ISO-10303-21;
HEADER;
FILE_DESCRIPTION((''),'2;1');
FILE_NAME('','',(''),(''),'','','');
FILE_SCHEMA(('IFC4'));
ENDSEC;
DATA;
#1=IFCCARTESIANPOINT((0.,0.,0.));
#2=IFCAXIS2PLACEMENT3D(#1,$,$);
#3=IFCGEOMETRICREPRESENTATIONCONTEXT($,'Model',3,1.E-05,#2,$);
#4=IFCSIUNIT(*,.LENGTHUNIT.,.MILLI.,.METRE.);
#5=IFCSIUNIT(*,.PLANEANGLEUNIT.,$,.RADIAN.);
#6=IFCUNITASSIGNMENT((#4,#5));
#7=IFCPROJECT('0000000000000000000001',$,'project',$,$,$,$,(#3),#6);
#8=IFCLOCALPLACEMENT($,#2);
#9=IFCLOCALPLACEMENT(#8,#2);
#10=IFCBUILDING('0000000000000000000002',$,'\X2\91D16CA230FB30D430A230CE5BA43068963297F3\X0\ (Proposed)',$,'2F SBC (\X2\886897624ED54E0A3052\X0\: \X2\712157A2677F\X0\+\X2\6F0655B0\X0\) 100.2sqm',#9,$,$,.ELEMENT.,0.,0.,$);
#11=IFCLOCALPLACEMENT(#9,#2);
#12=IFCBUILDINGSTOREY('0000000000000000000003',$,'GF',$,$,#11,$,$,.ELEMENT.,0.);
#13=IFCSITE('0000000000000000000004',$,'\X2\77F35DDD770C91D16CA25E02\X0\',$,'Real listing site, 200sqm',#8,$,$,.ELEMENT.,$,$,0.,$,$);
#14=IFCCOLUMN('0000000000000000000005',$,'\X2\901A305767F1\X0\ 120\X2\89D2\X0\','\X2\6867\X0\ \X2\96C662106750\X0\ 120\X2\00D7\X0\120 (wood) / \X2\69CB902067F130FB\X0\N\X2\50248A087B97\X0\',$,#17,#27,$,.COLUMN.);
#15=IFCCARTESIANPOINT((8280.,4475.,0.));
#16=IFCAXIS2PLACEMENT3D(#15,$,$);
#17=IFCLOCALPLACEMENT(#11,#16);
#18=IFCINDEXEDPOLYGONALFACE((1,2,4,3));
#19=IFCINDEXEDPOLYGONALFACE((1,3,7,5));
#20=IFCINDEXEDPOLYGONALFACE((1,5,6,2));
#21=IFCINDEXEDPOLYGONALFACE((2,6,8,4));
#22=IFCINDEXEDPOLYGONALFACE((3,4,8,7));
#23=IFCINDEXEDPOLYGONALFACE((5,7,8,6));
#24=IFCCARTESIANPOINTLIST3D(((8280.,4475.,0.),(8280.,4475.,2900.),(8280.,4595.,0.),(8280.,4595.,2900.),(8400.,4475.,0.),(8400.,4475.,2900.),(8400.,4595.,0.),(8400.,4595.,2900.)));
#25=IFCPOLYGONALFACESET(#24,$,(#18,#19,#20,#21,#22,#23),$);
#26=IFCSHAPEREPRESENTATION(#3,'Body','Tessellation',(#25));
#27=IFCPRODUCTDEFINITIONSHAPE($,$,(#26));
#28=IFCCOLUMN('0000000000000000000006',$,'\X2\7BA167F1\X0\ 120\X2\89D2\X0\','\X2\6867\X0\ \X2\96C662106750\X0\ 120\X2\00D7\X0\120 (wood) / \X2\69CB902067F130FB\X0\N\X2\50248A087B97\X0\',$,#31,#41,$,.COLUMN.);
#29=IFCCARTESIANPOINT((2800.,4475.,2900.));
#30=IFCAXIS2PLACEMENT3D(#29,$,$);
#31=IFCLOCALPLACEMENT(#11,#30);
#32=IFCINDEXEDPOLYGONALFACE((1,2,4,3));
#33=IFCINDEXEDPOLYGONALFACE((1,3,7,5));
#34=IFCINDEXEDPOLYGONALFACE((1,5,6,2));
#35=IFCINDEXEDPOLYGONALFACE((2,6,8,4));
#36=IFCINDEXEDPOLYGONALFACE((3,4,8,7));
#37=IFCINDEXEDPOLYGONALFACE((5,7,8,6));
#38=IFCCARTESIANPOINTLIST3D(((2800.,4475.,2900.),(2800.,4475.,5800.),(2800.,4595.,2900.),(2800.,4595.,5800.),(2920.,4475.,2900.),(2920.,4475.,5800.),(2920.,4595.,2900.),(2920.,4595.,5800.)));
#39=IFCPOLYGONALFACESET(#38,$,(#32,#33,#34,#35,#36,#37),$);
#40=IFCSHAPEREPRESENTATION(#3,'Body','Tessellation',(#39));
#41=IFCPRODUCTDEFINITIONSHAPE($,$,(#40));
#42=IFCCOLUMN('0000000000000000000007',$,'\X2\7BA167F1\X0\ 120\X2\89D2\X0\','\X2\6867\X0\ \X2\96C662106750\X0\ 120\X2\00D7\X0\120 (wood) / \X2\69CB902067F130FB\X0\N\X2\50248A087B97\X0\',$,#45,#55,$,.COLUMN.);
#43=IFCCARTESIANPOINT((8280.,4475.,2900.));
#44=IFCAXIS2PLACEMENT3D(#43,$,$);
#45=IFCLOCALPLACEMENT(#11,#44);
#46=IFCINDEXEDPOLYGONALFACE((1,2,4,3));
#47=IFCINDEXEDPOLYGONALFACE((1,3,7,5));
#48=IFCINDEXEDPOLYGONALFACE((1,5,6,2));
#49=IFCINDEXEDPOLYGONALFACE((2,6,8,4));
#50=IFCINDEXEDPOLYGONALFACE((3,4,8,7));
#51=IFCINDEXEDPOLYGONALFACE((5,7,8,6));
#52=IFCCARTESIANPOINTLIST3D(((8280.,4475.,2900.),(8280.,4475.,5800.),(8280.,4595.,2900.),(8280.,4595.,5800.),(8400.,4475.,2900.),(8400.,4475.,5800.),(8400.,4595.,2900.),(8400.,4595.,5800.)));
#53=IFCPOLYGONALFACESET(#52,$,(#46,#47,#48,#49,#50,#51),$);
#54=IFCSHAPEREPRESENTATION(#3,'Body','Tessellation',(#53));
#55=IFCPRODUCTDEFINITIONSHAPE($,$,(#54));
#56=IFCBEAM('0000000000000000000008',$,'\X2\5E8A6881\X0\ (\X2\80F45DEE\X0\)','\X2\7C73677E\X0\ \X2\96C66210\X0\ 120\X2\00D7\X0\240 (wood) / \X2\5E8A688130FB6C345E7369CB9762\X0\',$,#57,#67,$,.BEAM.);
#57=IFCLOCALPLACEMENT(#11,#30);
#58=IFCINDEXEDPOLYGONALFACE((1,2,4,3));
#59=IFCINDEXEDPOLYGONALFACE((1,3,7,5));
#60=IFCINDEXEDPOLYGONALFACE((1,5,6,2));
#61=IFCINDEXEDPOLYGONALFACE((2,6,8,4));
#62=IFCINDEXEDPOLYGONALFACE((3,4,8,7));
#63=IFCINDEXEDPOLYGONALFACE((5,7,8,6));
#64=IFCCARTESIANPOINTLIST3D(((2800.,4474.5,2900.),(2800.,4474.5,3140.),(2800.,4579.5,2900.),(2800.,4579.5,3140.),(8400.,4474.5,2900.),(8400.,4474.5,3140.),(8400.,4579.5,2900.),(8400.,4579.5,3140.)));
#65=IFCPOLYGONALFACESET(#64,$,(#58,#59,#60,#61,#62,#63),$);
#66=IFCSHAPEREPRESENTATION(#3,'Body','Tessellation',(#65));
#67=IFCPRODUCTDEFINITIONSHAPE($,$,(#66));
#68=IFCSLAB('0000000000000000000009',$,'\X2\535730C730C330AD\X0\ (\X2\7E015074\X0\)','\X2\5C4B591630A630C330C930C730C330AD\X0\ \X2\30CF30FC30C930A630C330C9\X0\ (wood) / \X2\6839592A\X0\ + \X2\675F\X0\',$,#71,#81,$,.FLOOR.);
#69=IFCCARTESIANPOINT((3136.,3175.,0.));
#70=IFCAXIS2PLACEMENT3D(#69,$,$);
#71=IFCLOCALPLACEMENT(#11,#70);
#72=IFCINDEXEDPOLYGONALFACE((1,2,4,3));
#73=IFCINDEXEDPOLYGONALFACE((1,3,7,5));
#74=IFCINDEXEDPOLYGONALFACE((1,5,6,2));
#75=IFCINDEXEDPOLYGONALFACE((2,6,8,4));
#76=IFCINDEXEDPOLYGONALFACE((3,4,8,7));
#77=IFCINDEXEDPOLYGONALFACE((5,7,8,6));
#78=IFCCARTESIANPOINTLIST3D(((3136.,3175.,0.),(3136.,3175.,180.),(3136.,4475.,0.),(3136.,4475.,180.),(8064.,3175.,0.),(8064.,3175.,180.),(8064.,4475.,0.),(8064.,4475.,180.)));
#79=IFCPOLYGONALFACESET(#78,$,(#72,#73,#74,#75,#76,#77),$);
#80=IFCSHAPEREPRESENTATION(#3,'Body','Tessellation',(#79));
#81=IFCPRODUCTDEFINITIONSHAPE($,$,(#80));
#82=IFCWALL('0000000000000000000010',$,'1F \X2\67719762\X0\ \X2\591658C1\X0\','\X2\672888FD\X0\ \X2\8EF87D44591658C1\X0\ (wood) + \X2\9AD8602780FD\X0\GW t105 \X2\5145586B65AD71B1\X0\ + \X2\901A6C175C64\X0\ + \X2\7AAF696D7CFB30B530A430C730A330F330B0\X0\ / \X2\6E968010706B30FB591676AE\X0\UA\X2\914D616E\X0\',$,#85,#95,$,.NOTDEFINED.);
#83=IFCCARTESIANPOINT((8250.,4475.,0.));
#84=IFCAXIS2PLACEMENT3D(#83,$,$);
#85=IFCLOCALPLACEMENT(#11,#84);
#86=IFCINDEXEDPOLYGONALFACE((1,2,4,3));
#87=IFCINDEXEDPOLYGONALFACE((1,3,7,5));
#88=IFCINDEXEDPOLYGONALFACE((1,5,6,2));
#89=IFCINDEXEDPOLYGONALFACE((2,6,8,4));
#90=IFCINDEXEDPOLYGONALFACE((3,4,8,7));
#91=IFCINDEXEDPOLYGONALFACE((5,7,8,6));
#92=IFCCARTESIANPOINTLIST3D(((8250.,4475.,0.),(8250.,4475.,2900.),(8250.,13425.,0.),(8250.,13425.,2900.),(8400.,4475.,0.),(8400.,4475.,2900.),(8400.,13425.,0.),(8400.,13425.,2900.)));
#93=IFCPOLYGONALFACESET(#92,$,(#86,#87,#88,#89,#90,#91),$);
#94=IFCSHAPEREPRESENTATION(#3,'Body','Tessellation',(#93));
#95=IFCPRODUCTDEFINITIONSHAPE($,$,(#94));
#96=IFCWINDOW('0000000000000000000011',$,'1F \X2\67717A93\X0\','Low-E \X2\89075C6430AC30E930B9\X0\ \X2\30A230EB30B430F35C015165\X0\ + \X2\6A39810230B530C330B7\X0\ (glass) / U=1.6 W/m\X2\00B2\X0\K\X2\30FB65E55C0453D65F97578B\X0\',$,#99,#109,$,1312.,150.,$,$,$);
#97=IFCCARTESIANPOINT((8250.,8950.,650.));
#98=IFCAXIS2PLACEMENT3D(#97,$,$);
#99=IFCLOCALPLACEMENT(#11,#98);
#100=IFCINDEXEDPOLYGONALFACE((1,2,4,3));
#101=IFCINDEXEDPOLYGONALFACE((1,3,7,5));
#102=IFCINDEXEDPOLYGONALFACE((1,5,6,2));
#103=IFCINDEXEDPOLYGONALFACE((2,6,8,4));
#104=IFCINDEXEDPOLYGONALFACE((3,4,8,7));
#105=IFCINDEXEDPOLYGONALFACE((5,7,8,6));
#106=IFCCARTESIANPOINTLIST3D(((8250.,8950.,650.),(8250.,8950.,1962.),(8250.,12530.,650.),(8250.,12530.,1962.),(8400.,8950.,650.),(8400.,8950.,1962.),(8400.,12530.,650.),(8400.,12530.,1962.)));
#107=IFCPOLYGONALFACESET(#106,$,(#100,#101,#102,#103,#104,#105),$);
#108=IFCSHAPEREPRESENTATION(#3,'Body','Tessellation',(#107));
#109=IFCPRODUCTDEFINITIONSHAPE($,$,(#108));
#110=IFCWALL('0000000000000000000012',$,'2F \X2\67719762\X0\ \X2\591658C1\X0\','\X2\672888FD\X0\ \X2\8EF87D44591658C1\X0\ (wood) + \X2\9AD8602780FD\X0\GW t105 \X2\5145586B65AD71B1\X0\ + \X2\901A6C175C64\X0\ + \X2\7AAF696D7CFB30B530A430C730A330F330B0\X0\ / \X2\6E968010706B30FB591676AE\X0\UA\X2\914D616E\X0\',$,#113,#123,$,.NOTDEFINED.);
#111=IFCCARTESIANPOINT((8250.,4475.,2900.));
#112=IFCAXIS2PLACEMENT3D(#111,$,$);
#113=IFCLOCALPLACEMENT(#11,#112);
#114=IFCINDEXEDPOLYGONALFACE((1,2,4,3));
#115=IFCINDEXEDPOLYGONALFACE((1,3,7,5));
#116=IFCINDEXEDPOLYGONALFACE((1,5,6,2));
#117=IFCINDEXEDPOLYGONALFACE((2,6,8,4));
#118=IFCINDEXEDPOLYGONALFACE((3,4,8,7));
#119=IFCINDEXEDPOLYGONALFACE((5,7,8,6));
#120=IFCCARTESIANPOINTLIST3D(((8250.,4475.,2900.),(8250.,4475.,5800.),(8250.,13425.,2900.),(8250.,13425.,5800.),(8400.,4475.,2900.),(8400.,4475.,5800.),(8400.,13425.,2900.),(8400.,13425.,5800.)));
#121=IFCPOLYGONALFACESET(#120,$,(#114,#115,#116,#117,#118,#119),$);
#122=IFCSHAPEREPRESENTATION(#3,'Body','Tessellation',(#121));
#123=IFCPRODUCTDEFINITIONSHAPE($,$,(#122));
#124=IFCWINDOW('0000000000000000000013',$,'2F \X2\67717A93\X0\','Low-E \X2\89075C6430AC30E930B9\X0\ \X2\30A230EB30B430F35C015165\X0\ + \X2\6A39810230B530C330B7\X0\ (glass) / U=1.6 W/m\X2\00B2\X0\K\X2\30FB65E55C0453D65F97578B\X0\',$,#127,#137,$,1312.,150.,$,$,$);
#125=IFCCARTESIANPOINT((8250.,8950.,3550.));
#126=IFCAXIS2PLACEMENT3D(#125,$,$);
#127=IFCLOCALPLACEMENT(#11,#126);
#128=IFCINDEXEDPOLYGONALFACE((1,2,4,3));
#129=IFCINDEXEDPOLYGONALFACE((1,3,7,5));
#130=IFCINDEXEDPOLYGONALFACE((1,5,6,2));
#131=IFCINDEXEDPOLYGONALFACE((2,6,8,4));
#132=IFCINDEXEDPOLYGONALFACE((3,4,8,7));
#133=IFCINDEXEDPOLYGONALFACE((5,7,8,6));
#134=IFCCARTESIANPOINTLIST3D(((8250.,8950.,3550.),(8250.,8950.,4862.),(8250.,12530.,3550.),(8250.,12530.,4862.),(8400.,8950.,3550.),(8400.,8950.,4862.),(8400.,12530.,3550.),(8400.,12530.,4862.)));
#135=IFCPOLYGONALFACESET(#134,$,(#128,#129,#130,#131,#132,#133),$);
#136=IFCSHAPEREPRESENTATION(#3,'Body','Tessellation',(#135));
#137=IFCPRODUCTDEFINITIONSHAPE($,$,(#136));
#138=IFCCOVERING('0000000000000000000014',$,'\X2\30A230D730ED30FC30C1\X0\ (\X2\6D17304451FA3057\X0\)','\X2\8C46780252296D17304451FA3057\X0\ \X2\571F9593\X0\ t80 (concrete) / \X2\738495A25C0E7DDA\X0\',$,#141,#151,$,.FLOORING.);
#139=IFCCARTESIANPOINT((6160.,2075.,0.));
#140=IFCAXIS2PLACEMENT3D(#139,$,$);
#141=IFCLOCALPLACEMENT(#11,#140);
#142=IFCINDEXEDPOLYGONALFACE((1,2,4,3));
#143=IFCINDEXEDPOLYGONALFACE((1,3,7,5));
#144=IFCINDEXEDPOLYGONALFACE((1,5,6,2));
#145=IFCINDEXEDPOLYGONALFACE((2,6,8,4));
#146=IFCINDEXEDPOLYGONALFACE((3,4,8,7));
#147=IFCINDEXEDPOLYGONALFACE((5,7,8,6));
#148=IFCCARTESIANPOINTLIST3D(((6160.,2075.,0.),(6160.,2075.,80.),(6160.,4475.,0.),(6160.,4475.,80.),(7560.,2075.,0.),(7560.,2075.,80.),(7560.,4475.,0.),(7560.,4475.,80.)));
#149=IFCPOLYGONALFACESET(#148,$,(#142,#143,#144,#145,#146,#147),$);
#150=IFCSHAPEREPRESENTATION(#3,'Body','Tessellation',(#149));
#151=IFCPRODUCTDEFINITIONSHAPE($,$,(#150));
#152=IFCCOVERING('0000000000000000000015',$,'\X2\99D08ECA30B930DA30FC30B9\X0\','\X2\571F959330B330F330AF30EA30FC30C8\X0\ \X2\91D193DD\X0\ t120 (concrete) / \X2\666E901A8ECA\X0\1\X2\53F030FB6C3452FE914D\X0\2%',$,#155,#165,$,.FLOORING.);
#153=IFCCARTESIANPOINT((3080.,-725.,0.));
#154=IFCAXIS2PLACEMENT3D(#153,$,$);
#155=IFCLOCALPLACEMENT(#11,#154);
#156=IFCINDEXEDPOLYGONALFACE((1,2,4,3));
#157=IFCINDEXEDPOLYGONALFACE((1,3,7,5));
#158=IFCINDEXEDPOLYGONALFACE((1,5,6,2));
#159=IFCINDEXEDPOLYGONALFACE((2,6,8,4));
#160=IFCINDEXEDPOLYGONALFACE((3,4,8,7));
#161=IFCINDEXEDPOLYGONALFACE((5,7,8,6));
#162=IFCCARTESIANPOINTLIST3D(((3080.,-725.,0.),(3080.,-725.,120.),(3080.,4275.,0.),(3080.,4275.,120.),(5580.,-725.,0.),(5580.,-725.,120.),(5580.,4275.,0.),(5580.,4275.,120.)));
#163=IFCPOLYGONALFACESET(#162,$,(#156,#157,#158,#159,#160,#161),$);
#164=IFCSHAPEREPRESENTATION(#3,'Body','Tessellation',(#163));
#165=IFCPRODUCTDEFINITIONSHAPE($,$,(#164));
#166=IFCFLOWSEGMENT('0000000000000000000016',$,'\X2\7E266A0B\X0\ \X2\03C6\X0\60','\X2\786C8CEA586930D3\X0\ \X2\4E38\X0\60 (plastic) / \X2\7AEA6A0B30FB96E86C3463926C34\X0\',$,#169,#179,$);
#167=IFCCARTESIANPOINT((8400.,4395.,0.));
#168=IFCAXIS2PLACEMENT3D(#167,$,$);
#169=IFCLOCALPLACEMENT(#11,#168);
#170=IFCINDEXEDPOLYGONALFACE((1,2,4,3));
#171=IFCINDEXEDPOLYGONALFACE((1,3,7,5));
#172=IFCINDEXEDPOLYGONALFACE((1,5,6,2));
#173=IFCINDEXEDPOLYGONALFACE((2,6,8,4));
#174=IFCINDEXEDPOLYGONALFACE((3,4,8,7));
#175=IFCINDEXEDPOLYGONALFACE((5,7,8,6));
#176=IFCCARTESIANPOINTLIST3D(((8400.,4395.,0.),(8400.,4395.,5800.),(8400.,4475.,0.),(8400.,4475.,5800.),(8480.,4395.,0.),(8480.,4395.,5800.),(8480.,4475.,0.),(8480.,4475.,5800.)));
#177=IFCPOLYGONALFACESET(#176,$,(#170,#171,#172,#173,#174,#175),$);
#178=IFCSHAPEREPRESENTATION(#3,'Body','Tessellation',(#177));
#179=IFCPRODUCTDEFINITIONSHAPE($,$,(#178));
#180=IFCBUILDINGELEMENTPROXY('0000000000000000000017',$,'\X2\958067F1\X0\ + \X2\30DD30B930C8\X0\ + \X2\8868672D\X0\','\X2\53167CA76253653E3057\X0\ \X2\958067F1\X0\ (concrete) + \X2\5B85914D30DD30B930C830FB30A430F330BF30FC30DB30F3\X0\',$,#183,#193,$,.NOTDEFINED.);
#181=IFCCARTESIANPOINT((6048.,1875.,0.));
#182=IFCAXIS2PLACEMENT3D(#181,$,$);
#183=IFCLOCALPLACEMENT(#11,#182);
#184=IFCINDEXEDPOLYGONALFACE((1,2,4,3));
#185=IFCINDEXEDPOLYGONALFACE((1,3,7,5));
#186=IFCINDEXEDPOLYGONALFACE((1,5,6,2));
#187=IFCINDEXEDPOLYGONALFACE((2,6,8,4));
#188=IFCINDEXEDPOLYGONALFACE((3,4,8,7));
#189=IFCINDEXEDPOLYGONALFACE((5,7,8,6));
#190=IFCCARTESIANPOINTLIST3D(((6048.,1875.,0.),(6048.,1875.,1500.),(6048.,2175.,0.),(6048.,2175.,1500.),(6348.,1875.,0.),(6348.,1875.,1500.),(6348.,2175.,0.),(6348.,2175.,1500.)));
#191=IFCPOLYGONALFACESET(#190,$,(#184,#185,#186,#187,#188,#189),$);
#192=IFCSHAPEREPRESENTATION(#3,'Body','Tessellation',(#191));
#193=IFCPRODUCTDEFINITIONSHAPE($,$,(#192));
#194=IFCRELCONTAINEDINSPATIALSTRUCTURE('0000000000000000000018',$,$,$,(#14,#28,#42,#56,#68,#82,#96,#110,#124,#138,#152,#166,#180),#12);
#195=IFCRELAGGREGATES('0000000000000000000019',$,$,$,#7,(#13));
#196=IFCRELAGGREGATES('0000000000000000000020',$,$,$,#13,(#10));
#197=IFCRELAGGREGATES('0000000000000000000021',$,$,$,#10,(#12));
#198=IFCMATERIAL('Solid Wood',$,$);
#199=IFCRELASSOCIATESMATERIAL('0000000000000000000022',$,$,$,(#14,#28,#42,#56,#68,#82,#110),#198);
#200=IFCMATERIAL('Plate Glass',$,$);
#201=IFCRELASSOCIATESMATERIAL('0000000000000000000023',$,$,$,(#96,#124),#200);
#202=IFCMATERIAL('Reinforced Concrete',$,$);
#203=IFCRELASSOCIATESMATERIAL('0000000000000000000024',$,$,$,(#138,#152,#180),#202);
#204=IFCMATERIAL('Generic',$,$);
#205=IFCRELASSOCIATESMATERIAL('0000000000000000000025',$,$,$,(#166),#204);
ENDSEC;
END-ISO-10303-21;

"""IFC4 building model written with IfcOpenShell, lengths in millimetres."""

from ifc_helpers import new_model, si_unit, frame, frame_2d, origin, place, context, project, spatial, rectangle, extrude, material, element, fill, save


model = new_model("IFC4")

# Units and contexts
model_context = context("Model", 3, precision=1e-05, world=origin())
ifc_project = project(units=[si_unit("LENGTHUNIT", "METRE", prefix="MILLI"), si_unit("PLANEANGLEUNIT", "RADIAN")], contexts=[model_context])

# Site, building, storey
site_placement = place(None, origin())
site = spatial("IfcSite", under=ifc_project, at=site_placement, Name="石川県金沢市", ObjectType="Real listing site, 200sqm", CompositionType="ELEMENT", RefElevation=0.0)
building_placement = place(site_placement, origin())
building = spatial("IfcBuilding", under=site, at=building_placement, Name="金沢・ピアノ室と防音 (Proposed)", ObjectType="2F SBC (表面仕上げ: 無垢板+漆喰) 100.2sqm", CompositionType="ELEMENT", ElevationOfRefHeight=0.0, ElevationOfTerrain=0.0)
storey_placement = place(building_placement, origin())
storey = spatial("IfcBuildingStorey", under=building, at=storey_placement, Name="GF", CompositionType="ELEMENT", Elevation=0.0)

# Columns
ifc_material_1 = material(Name="Solid Wood")
column_1_placement = place(storey_placement, frame((8280.0, 4475.0, 0.0)))
element("IfcColumn", 1, at=column_1_placement, inside=storey, material=ifc_material_1, Name="通し柱 120角", Description="桧 集成材 120×120 (wood) / 構造柱・N値計算", PredefinedType="COLUMN", context=model_context, shape_type="SweptSolid", body=[
    extrude(rectangle(XDim=120.0, YDim=120.0, at=frame_2d((60.0, 60.0))), frame((8280.0, 4475.0, 0.0)), (0.0, 0.0, 1.0), 2900.0),
])
column_2_placement = place(storey_placement, frame((2800.0, 4475.0, 2900.0)))
element("IfcColumn", 2, at=column_2_placement, inside=storey, material=ifc_material_1, Name="管柱 120角", Description="桧 集成材 120×120 (wood) / 構造柱・N値計算", PredefinedType="COLUMN", context=model_context, shape_type="SweptSolid", body=[
    extrude(rectangle(XDim=120.0, YDim=120.0, at=frame_2d((60.0, 60.0))), frame((2800.0, 4475.0, 2900.0)), (0.0, 0.0, 1.0), 2900.0),
])
column_3_placement = place(storey_placement, frame((8280.0, 4475.0, 2900.0)))
element("IfcColumn", 3, at=column_3_placement, inside=storey, material=ifc_material_1, Name="管柱 120角", Description="桧 集成材 120×120 (wood) / 構造柱・N値計算", PredefinedType="COLUMN", context=model_context, shape_type="SweptSolid", body=[
    extrude(rectangle(XDim=120.0, YDim=120.0, at=frame_2d((60.0, 60.0))), frame((8280.0, 4475.0, 2900.0)), (0.0, 0.0, 1.0), 2900.0),
])

# Beam
beam_1_placement = place(storey_placement, frame((2800.0, 4475.0, 2900.0)))
element("IfcBeam", 4, at=beam_1_placement, inside=storey, material=ifc_material_1, Name="床梁 (胴差)", Description="米松 集成 120×240 (wood) / 床梁・水平構面", PredefinedType="BEAM", context=model_context, shape_type="SweptSolid", body=[
    extrude(rectangle(XDim=5600.0, YDim=105.0, at=frame_2d((2800.0, 52.0))), frame((2800.0, 4475.0, 2900.0)), (0.0, 0.0, 1.0), 240.0),
])

# Slab
slab_placement = place(storey_placement, frame((3136.0, 3175.0, 0.0)))
element("IfcSlab", 5, at=slab_placement, inside=storey, material=ifc_material_1, Name="南デッキ (縁側)", Description="屋外ウッドデッキ ハードウッド (wood) / 根太 + 束", PredefinedType="FLOOR", context=model_context, shape_type="SweptSolid", body=[
    extrude(rectangle(XDim=4928.0, YDim=1300.0, at=frame_2d((2464.0, 650.0))), frame((3136.0, 3175.0, 0.0)), (0.0, 0.0, 1.0), 180.0),
])

# Walls, openings, windows
wall_1_placement = place(storey_placement, frame((8250.0, 4475.0, 0.0)))
wall_1 = element("IfcWall", 6, at=wall_1_placement, inside=storey, material=ifc_material_1, Name="1F 東面 外壁", Description="木製 軸組外壁 (wood) + 高性能GW t105 充填断熱 + 通気層 + 窯業系サイディング / 準耐火・外皮UA配慮", PredefinedType="NOTDEFINED", context=model_context, shape_type="SweptSolid", body=[
    extrude(rectangle(XDim=150.0, YDim=8950.0, at=frame_2d((75.0, 4475.0))), frame((8250.0, 4475.0, 0.0)), (0.0, 0.0, 1.0), 2900.0),
])
opening_1_placement = place(storey_placement, frame((8250.0, 8950.0, 650.0)))
opening_1 = element("IfcOpeningElement", 7, at=opening_1_placement, cuts=wall_1, PredefinedType="NOTDEFINED", context=model_context, shape_type="SweptSolid", body=[
    extrude(rectangle(XDim=150.0, YDim=3580.0, at=frame_2d((75.0, 1790.0))), frame((8250.0, 8950.0, 650.0)), (0.0, 0.0, 1.0), 1312.0),
])
ifc_material_2 = material(Name="Plate Glass")
window_1_placement = place(storey_placement, frame((8250.0, 8950.0, 650.0)))
window_1 = element("IfcWindow", 8, at=window_1_placement, inside=storey, material=ifc_material_2, Name="1F 東窓", Description="Low-E 複層ガラス アルゴン封入 + 樹脂サッシ (glass) / U=1.6 W/m²K・日射取得型", OverallHeight=1312.0, OverallWidth=150.0, context=model_context, shape_type="SweptSolid", body=[
    extrude(rectangle(XDim=150.0, YDim=3580.0, at=frame_2d((75.0, 1790.0))), frame((8250.0, 8950.0, 650.0)), (0.0, 0.0, 1.0), 1312.0),
])
fill(opening_1, window_1)
wall_2_placement = place(storey_placement, frame((8250.0, 4475.0, 2900.0)))
wall_2 = element("IfcWall", 9, at=wall_2_placement, inside=storey, material=ifc_material_1, Name="2F 東面 外壁", Description="木製 軸組外壁 (wood) + 高性能GW t105 充填断熱 + 通気層 + 窯業系サイディング / 準耐火・外皮UA配慮", PredefinedType="NOTDEFINED", context=model_context, shape_type="SweptSolid", body=[
    extrude(rectangle(XDim=150.0, YDim=8950.0, at=frame_2d((75.0, 4475.0))), frame((8250.0, 4475.0, 2900.0)), (0.0, 0.0, 1.0), 2900.0),
])
opening_2_placement = place(storey_placement, frame((8250.0, 8950.0, 3550.0)))
opening_2 = element("IfcOpeningElement", 10, at=opening_2_placement, cuts=wall_2, PredefinedType="NOTDEFINED", context=model_context, shape_type="SweptSolid", body=[
    extrude(rectangle(XDim=150.0, YDim=3580.0, at=frame_2d((75.0, 1790.0))), frame((8250.0, 8950.0, 3550.0)), (0.0, 0.0, 1.0), 1312.0),
])
window_2_placement = place(storey_placement, frame((8250.0, 8950.0, 3550.0)))
window_2 = element("IfcWindow", 11, at=window_2_placement, inside=storey, material=ifc_material_2, Name="2F 東窓", Description="Low-E 複層ガラス アルゴン封入 + 樹脂サッシ (glass) / U=1.6 W/m²K・日射取得型", OverallHeight=1312.0, OverallWidth=150.0, context=model_context, shape_type="SweptSolid", body=[
    extrude(rectangle(XDim=150.0, YDim=3580.0, at=frame_2d((75.0, 1790.0))), frame((8250.0, 8950.0, 3550.0)), (0.0, 0.0, 1.0), 1312.0),
])
fill(opening_2, window_2)

# Coverings
ifc_material_3 = material(Name="Reinforced Concrete")
covering_1_placement = place(storey_placement, frame((6160.0, 2075.0, 0.0)))
element("IfcCovering", 12, at=covering_1_placement, inside=storey, material=ifc_material_3, Name="アプローチ (洗い出し)", Description="豆砂利洗い出し 土間 t80 (concrete) / 玄関導線", PredefinedType="FLOORING", context=model_context, shape_type="SweptSolid", body=[
    extrude(rectangle(XDim=1400.0, YDim=2400.0, at=frame_2d((700.0, 1200.0))), frame((6160.0, 2075.0, 0.0)), (0.0, 0.0, 1.0), 80.0),
])
covering_2_placement = place(storey_placement, frame((3080.0, -725.0, 0.0)))
element("IfcCovering", 13, at=covering_2_placement, inside=storey, material=ifc_material_3, Name="駐車スペース", Description="土間コンクリート 金鏝 t120 (concrete) / 普通車1台・水勾配2%", PredefinedType="FLOORING", context=model_context, shape_type="SweptSolid", body=[
    extrude(rectangle(XDim=2500.0, YDim=5000.0, at=frame_2d((1250.0, 2500.0))), frame((3080.0, -725.0, 0.0)), (0.0, 0.0, 1.0), 120.0),
])

# Flow segment
ifc_material_4 = material(Name="Generic")
flow_segment_placement = place(storey_placement, frame((8400.0, 4395.0, 0.0)))
element("IfcFlowSegment", 14, at=flow_segment_placement, inside=storey, material=ifc_material_4, Name="縦樋 φ60", Description="硬質塩ビ 丸60 (plastic) / 竪樋・雨水排水", context=model_context, shape_type="SweptSolid", body=[
    extrude(rectangle(XDim=80.0, YDim=80.0, at=frame_2d((40.0, 40.0))), frame((8400.0, 4395.0, 0.0)), (0.0, 0.0, 1.0), 5800.0),
])

# Building element proxy
proxy_placement = place(storey_placement, frame((6048.0, 1875.0, 0.0)))
element("IfcBuildingElementProxy", 15, at=proxy_placement, inside=storey, material=ifc_material_3, Name="門柱 + ポスト + 表札", Description="化粧打放し 門柱 (concrete) + 宅配ポスト・インターホン", PredefinedType="NOTDEFINED", context=model_context, shape_type="SweptSolid", body=[
    extrude(rectangle(XDim=300.0, YDim=300.0, at=frame_2d((150.0, 150.0))), frame((6048.0, 1875.0, 0.0)), (0.0, 0.0, 1.0), 1500.0),
])

save(model, "model.ifc")
